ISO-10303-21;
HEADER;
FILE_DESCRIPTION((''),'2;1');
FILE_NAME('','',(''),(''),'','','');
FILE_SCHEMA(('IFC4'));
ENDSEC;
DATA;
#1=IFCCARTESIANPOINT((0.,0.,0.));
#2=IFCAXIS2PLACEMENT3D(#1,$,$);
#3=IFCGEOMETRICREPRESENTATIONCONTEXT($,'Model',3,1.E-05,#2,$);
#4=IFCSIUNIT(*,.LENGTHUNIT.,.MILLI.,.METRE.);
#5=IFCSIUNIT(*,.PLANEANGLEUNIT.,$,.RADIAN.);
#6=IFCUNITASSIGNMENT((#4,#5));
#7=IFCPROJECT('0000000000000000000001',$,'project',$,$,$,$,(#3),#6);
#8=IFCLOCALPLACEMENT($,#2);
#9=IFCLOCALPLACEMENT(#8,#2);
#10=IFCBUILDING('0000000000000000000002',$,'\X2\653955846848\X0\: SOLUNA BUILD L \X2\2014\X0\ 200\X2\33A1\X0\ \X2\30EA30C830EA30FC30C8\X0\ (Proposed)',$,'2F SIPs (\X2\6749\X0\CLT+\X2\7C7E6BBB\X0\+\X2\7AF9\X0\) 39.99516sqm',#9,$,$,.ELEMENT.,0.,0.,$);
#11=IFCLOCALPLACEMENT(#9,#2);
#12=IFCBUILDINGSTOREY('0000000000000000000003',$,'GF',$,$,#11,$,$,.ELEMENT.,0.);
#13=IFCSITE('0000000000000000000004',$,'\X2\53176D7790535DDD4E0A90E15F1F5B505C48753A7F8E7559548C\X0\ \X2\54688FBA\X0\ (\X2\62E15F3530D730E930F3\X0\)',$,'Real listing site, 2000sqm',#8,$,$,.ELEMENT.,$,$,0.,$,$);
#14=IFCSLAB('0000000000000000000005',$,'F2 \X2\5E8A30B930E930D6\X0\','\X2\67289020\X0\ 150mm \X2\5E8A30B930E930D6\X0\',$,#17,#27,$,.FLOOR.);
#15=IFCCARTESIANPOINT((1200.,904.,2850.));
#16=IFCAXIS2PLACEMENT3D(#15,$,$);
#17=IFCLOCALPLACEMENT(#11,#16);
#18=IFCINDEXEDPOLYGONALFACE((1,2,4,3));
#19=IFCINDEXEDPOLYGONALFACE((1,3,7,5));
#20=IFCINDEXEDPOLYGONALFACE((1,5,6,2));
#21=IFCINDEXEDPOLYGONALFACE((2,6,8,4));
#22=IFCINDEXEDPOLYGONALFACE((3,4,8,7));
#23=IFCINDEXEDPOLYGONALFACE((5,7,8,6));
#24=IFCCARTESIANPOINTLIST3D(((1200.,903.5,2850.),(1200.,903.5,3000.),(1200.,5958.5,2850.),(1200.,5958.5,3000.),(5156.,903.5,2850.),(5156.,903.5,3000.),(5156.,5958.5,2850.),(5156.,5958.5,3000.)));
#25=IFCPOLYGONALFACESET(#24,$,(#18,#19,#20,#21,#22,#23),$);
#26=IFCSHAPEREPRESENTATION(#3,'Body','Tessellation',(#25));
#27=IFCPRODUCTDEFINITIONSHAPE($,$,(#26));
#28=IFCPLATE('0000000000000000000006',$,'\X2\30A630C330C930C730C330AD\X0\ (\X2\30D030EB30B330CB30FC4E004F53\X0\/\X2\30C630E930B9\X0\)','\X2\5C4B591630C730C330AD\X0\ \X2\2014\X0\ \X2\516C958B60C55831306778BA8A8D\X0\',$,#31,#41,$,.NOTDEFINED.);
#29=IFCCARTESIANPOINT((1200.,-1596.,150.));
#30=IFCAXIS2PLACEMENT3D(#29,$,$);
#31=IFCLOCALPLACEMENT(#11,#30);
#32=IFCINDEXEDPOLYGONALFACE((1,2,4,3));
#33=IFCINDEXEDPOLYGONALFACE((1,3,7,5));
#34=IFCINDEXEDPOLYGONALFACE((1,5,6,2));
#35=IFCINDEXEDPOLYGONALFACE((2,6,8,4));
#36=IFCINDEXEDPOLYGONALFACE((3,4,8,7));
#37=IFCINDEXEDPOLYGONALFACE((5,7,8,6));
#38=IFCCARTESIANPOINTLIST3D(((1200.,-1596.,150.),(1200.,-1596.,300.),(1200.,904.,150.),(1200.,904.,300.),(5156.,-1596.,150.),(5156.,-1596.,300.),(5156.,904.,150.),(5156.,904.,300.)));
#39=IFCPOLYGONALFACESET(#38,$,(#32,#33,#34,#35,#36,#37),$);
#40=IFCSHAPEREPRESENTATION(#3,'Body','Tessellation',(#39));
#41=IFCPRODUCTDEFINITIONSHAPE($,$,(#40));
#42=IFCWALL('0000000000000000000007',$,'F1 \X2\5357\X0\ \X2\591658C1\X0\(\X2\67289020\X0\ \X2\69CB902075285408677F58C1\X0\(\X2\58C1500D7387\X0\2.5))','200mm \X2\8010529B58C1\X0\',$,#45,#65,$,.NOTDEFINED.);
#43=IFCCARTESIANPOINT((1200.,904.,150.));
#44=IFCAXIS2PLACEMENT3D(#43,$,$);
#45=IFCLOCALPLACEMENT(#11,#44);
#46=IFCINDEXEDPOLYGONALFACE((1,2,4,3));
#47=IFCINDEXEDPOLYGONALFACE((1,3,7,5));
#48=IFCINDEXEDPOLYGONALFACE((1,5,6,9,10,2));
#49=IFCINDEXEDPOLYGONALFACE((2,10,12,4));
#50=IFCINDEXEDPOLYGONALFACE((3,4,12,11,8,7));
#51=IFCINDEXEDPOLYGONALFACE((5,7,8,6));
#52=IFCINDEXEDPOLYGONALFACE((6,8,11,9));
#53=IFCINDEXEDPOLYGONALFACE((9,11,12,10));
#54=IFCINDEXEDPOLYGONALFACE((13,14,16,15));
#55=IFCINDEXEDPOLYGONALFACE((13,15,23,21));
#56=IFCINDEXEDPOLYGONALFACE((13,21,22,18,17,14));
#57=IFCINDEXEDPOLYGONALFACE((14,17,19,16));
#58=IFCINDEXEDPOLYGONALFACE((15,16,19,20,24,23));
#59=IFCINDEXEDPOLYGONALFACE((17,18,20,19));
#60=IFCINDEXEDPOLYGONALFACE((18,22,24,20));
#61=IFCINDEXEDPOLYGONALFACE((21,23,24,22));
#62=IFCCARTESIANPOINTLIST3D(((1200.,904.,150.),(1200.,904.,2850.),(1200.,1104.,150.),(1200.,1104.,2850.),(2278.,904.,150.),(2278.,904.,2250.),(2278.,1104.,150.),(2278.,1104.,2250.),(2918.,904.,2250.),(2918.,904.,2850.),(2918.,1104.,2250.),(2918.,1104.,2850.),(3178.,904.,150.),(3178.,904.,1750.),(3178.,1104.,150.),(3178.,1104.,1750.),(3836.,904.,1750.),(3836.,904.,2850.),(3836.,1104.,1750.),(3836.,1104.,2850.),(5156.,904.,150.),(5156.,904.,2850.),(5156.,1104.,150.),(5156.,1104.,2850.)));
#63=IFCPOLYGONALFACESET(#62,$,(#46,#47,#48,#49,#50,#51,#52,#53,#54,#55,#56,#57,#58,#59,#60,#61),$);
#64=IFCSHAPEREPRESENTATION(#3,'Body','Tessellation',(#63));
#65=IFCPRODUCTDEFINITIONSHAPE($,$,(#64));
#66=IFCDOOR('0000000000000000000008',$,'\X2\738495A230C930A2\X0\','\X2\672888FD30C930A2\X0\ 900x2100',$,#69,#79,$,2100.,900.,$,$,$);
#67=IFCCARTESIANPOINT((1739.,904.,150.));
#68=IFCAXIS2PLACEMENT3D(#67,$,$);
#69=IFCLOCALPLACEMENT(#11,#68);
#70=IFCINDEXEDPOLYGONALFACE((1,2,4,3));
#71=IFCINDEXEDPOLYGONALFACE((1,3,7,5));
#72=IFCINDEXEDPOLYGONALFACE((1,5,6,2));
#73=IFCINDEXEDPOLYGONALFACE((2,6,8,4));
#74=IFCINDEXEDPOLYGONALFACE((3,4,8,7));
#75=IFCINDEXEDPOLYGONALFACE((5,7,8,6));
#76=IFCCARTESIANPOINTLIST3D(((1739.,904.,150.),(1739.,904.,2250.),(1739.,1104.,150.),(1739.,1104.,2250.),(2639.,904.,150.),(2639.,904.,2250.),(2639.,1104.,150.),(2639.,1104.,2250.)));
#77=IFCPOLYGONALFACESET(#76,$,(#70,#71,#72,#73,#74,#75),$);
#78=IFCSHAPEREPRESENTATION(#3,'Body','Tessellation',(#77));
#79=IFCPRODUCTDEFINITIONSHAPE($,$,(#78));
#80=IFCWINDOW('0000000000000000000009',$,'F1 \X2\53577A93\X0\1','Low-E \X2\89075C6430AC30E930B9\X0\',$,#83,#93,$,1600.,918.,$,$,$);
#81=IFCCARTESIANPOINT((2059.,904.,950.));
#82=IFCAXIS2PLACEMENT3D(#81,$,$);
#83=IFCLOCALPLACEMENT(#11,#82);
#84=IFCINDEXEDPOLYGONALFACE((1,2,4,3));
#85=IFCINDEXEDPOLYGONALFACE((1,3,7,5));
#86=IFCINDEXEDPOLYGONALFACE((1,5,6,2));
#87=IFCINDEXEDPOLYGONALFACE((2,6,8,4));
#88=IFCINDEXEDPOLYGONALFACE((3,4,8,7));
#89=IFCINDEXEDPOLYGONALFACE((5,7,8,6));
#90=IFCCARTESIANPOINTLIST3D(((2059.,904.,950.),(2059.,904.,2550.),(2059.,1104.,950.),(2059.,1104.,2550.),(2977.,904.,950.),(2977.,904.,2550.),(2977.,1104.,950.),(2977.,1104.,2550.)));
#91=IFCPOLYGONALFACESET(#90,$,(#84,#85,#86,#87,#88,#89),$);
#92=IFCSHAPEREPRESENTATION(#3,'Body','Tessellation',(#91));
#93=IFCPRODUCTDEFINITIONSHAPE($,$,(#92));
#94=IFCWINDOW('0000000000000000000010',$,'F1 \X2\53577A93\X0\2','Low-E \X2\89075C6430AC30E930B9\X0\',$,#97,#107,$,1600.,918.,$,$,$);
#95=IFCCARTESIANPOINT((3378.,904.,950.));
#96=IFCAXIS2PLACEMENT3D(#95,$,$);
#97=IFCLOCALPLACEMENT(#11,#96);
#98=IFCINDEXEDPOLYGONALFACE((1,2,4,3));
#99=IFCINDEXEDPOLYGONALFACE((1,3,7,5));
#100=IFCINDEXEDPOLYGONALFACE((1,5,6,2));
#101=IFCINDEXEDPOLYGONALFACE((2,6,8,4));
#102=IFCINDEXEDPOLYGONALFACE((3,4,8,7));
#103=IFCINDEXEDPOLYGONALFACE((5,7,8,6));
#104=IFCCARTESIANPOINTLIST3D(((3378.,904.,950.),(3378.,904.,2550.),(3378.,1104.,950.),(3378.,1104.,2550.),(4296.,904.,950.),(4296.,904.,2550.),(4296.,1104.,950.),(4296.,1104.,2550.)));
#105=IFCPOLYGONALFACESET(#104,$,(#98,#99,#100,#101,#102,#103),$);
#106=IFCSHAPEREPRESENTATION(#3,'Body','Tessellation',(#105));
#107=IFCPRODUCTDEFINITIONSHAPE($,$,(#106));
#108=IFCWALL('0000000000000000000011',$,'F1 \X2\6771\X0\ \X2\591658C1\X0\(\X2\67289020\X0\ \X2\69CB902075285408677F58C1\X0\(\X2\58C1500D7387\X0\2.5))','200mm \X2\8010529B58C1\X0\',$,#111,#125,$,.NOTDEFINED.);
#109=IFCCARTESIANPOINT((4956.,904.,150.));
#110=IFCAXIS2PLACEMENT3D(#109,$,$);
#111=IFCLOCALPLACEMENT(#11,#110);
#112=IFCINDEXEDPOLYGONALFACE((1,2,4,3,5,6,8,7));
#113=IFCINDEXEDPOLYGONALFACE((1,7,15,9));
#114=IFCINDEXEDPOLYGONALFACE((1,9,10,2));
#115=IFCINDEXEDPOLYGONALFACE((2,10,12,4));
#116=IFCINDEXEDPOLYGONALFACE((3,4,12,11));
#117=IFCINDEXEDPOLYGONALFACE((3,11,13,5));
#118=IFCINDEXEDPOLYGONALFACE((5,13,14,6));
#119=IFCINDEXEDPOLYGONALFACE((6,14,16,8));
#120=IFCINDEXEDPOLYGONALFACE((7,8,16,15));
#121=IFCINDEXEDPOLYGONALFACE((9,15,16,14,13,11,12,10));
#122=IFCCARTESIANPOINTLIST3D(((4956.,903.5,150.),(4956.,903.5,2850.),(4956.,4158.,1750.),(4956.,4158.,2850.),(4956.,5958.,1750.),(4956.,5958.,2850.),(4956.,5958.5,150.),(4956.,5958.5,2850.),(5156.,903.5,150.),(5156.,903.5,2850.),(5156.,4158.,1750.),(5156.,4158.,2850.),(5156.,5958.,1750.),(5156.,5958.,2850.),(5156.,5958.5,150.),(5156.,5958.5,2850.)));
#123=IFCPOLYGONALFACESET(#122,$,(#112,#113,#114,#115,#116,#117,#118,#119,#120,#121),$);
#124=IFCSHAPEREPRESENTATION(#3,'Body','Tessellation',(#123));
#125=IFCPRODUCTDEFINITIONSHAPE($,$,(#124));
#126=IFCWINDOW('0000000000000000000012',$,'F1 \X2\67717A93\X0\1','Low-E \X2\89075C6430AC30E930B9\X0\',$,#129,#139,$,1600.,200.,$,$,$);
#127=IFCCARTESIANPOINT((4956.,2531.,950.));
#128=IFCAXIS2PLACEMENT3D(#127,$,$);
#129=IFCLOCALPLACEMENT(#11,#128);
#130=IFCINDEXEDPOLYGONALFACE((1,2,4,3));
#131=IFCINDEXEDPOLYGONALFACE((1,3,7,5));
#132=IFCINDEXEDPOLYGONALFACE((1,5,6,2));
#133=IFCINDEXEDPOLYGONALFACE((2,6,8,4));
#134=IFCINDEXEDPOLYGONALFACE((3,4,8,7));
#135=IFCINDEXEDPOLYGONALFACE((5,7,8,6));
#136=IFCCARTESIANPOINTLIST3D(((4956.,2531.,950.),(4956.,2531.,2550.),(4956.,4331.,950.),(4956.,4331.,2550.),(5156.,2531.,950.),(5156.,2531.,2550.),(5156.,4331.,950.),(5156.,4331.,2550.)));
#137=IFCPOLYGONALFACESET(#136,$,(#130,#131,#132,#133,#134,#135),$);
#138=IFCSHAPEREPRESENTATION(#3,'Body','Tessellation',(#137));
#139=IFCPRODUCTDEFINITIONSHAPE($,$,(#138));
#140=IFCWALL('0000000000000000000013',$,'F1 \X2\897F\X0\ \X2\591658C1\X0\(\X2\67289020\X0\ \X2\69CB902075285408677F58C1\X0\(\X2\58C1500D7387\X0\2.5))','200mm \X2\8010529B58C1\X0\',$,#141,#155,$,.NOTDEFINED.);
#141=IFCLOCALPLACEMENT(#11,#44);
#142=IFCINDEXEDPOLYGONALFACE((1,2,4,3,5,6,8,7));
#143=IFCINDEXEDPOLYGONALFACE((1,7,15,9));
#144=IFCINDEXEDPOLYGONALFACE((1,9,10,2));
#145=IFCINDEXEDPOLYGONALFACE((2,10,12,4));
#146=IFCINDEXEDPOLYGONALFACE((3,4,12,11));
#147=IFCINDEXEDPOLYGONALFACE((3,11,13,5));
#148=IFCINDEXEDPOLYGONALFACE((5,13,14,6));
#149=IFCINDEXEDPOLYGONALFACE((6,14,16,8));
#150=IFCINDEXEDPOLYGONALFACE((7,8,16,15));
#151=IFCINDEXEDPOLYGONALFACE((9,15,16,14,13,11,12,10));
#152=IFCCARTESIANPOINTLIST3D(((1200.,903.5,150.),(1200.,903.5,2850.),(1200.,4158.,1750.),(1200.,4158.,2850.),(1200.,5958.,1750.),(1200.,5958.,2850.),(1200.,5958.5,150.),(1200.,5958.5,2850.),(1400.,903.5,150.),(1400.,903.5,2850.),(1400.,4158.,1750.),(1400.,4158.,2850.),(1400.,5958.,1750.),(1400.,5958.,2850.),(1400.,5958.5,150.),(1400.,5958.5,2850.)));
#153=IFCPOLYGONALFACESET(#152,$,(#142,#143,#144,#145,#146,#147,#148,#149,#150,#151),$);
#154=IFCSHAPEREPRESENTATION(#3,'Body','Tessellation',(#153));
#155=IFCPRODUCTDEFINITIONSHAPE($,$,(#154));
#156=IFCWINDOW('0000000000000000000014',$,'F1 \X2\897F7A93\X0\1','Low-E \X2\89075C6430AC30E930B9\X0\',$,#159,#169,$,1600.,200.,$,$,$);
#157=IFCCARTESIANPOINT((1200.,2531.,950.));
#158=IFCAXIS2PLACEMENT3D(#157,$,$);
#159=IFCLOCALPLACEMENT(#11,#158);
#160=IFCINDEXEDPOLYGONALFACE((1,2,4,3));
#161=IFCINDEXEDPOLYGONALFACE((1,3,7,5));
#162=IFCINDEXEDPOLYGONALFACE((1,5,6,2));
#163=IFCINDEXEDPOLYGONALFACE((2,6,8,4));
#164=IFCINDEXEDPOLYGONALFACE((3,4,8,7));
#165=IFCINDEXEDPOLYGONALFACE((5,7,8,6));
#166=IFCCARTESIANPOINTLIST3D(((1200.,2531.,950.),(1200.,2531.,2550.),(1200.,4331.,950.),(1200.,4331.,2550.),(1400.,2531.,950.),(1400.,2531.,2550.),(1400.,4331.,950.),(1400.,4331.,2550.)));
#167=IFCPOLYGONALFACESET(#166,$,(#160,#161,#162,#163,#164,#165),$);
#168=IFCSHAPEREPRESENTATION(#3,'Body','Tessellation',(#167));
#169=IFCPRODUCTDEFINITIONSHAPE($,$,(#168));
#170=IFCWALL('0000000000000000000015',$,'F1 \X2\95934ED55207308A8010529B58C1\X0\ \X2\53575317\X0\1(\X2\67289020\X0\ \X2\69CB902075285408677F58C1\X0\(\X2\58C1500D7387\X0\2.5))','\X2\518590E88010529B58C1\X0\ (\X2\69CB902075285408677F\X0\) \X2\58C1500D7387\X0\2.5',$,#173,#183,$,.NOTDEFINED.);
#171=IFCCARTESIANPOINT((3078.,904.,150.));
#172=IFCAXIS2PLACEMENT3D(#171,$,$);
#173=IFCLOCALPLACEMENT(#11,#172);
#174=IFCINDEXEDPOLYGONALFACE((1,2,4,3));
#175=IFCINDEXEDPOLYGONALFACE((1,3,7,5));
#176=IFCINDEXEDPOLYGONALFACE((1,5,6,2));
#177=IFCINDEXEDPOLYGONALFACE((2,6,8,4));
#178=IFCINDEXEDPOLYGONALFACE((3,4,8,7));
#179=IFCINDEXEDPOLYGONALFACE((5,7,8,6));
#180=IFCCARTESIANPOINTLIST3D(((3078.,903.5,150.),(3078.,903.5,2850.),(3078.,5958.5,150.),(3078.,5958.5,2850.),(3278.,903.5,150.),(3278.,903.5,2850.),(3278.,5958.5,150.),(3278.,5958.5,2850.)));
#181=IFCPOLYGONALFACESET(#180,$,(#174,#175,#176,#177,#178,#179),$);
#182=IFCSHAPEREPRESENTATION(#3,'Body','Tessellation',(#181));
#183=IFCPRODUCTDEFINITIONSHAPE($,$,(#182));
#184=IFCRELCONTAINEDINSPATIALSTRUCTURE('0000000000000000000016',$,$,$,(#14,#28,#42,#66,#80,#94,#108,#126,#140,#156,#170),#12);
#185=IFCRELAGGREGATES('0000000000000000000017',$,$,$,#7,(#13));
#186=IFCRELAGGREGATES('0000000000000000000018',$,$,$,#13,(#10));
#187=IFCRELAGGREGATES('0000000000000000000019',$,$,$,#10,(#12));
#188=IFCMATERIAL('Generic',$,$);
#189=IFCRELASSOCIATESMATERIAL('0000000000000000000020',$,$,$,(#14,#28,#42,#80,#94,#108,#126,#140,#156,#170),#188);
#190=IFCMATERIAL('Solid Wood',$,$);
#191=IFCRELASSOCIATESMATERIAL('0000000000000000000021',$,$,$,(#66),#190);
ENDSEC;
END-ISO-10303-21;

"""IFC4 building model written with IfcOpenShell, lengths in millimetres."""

from ifc_helpers import new_model, si_unit, frame, frame_2d, origin, place, context, project, spatial, rectangle, extrude, material, element, fill, save


model = new_model("IFC4")

# Units and contexts
model_context = context("Model", 3, precision=1e-05, world=origin())
ifc_project = project(units=[si_unit("LENGTHUNIT", "METRE", prefix="MILLI"), si_unit("PLANEANGLEUNIT", "RADIAN")], contexts=[model_context])

# Site, building, storey
site_placement = place(None, origin())
site = spatial("IfcSite", under=ifc_project, at=site_placement, Name="北海道川上郡弟子屈町美留和 周辺 (拡張プラン)", ObjectType="Real listing site, 2000sqm", CompositionType="ELEMENT", RefElevation=0.0)
building_placement = place(site_placement, origin())
building = spatial("IfcBuilding", under=site, at=building_placement, Name="改善案: SOLUNA BUILD L — 200㎡ リトリート (Proposed)", ObjectType="2F SIPs (杉CLT+籾殻+竹) 39.99516sqm", CompositionType="ELEMENT", ElevationOfRefHeight=0.0, ElevationOfTerrain=0.0)
storey_placement = place(building_placement, origin())
storey = spatial("IfcBuildingStorey", under=building, at=storey_placement, Name="GF", CompositionType="ELEMENT", Elevation=0.0)

# Slab
ifc_material_1 = material(Name="Generic")
slab_1_placement = place(storey_placement, frame((1200.0, 904.0, 2850.0)))
element("IfcSlab", 1, at=slab_1_placement, inside=storey, material=ifc_material_1, Name="F2 床スラブ", Description="木造 150mm 床スラブ", PredefinedType="FLOOR", context=model_context, shape_type="SweptSolid", body=[
    extrude(rectangle(XDim=3956.0, YDim=5055.0, at=frame_2d((1978.0, 2527.0))), frame((1200.0, 904.0, 2850.0)), (0.0, 0.0, 1.0), 150.0),
])

# Plate
plate_placement = place(storey_placement, frame((1200.0, -1596.0, 150.0)))
element("IfcPlate", 2, at=plate_placement, inside=storey, material=ifc_material_1, Name="ウッドデッキ (バルコニー一体/テラス)", Description="屋外デッキ — 公開情報で確認", PredefinedType="NOTDEFINED", context=model_context, shape_type="SweptSolid", body=[
    extrude(rectangle(XDim=3956.0, YDim=2500.0, at=frame_2d((1978.0, 1250.0))), frame((1200.0, -1596.0, 150.0)), (0.0, 0.0, 1.0), 150.0),
])

# Wall, openings, door, windows
wall_1_placement = place(storey_placement, frame((1200.0, 904.0, 150.0)))
wall_1 = element("IfcWall", 3, at=wall_1_placement, inside=storey, material=ifc_material_1, Name="F1 南 外壁(木造 構造用合板壁(壁倍率2.5))", Description="200mm 耐力壁", PredefinedType="NOTDEFINED", context=model_context, shape_type="SweptSolid", body=[
    extrude(rectangle(XDim=3956.0, YDim=200.0, at=frame_2d((1978.0, 100.0))), frame((1200.0, 904.0, 150.0)), (0.0, 0.0, 1.0), 2700.0),
])
opening_1_placement = place(storey_placement, frame((1739.0, 904.0, 150.0)))
opening_1 = element("IfcOpeningElement", 4, at=opening_1_placement, cuts=wall_1, PredefinedType="NOTDEFINED", context=model_context, shape_type="SweptSolid", body=[
    extrude(rectangle(XDim=900.0, YDim=200.0, at=frame_2d((450.0, 100.0))), frame((1739.0, 904.0, 150.0)), (0.0, 0.0, 1.0), 2100.0),
])
opening_2_placement = place(storey_placement, frame((2059.0, 904.0, 950.0)))
opening_2 = element("IfcOpeningElement", 5, at=opening_2_placement, cuts=wall_1, PredefinedType="NOTDEFINED", context=model_context, shape_type="SweptSolid", body=[
    extrude(rectangle(XDim=918.0, YDim=200.0, at=frame_2d((459.0, 100.0))), frame((2059.0, 904.0, 950.0)), (0.0, 0.0, 1.0), 1600.0),
])
opening_3_placement = place(storey_placement, frame((3378.0, 904.0, 950.0)))
opening_3 = element("IfcOpeningElement", 6, at=opening_3_placement, cuts=wall_1, PredefinedType="NOTDEFINED", context=model_context, shape_type="SweptSolid", body=[
    extrude(rectangle(XDim=918.0, YDim=200.0, at=frame_2d((459.0, 100.0))), frame((3378.0, 904.0, 950.0)), (0.0, 0.0, 1.0), 1600.0),
])
ifc_material_2 = material(Name="Solid Wood")
door_placement = place(storey_placement, frame((1739.0, 904.0, 150.0)))
door = element("IfcDoor", 7, at=door_placement, inside=storey, material=ifc_material_2, Name="玄関ドア", Description="木製ドア 900x2100", OverallHeight=2100.0, OverallWidth=900.0, context=model_context, shape_type="SweptSolid", body=[
    extrude(rectangle(XDim=900.0, YDim=200.0, at=frame_2d((450.0, 100.0))), frame((1739.0, 904.0, 150.0)), (0.0, 0.0, 1.0), 2100.0),
])
fill(opening_1, door)
window_1_placement = place(storey_placement, frame((2059.0, 904.0, 950.0)))
window_1 = element("IfcWindow", 8, at=window_1_placement, inside=storey, material=ifc_material_1, Name="F1 南窓1", Description="Low-E 複層ガラス", OverallHeight=1600.0, OverallWidth=918.0, context=model_context, shape_type="SweptSolid", body=[
    extrude(rectangle(XDim=918.0, YDim=200.0, at=frame_2d((459.0, 100.0))), frame((2059.0, 904.0, 950.0)), (0.0, 0.0, 1.0), 1600.0),
])
fill(opening_2, window_1)
window_2_placement = place(storey_placement, frame((3378.0, 904.0, 950.0)))
window_2 = element("IfcWindow", 9, at=window_2_placement, inside=storey, material=ifc_material_1, Name="F1 南窓2", Description="Low-E 複層ガラス", OverallHeight=1600.0, OverallWidth=918.0, context=model_context, shape_type="SweptSolid", body=[
    extrude(rectangle(XDim=918.0, YDim=200.0, at=frame_2d((459.0, 100.0))), frame((3378.0, 904.0, 950.0)), (0.0, 0.0, 1.0), 1600.0),
])
fill(opening_3, window_2)

# Walls, openings, windows
wall_2_placement = place(storey_placement, frame((4956.0, 904.0, 150.0)))
wall_2 = element("IfcWall", 10, at=wall_2_placement, inside=storey, material=ifc_material_1, Name="F1 東 外壁(木造 構造用合板壁(壁倍率2.5))", Description="200mm 耐力壁", PredefinedType="NOTDEFINED", context=model_context, shape_type="SweptSolid", body=[
    extrude(rectangle(XDim=200.0, YDim=5055.0, at=frame_2d((100.0, 2527.0))), frame((4956.0, 904.0, 150.0)), (0.0, 0.0, 1.0), 2700.0),
])
opening_4_placement = place(storey_placement, frame((4956.0, 2531.0, 950.0)))
opening_4 = element("IfcOpeningElement", 11, at=opening_4_placement, cuts=wall_2, PredefinedType="NOTDEFINED", context=model_context, shape_type="SweptSolid", body=[
    extrude(rectangle(XDim=200.0, YDim=1800.0, at=frame_2d((100.0, 900.0))), frame((4956.0, 2531.0, 950.0)), (0.0, 0.0, 1.0), 1600.0),
])
window_3_placement = place(storey_placement, frame((4956.0, 2531.0, 950.0)))
window_3 = element("IfcWindow", 12, at=window_3_placement, inside=storey, material=ifc_material_1, Name="F1 東窓1", Description="Low-E 複層ガラス", OverallHeight=1600.0, OverallWidth=200.0, context=model_context, shape_type="SweptSolid", body=[
    extrude(rectangle(XDim=200.0, YDim=1800.0, at=frame_2d((100.0, 900.0))), frame((4956.0, 2531.0, 950.0)), (0.0, 0.0, 1.0), 1600.0),
])
fill(opening_4, window_3)
wall_3_placement = place(storey_placement, frame((1200.0, 904.0, 150.0)))
wall_3 = element("IfcWall", 13, at=wall_3_placement, inside=storey, material=ifc_material_1, Name="F1 西 外壁(木造 構造用合板壁(壁倍率2.5))", Description="200mm 耐力壁", PredefinedType="NOTDEFINED", context=model_context, shape_type="SweptSolid", body=[
    extrude(rectangle(XDim=200.0, YDim=5055.0, at=frame_2d((100.0, 2527.0))), frame((1200.0, 904.0, 150.0)), (0.0, 0.0, 1.0), 2700.0),
])
opening_5_placement = place(storey_placement, frame((1200.0, 2531.0, 950.0)))
opening_5 = element("IfcOpeningElement", 14, at=opening_5_placement, cuts=wall_3, PredefinedType="NOTDEFINED", context=model_context, shape_type="SweptSolid", body=[
    extrude(rectangle(XDim=200.0, YDim=1800.0, at=frame_2d((100.0, 900.0))), frame((1200.0, 2531.0, 950.0)), (0.0, 0.0, 1.0), 1600.0),
])
window_4_placement = place(storey_placement, frame((1200.0, 2531.0, 950.0)))
window_4 = element("IfcWindow", 15, at=window_4_placement, inside=storey, material=ifc_material_1, Name="F1 西窓1", Description="Low-E 複層ガラス", OverallHeight=1600.0, OverallWidth=200.0, context=model_context, shape_type="SweptSolid", body=[
    extrude(rectangle(XDim=200.0, YDim=1800.0, at=frame_2d((100.0, 900.0))), frame((1200.0, 2531.0, 950.0)), (0.0, 0.0, 1.0), 1600.0),
])
fill(opening_5, window_4)

# Wall
wall_4_placement = place(storey_placement, frame((3078.0, 904.0, 150.0)))
element("IfcWall", 16, at=wall_4_placement, inside=storey, material=ifc_material_1, Name="F1 間仕切り耐力壁 南北1(木造 構造用合板壁(壁倍率2.5))", Description="内部耐力壁 (構造用合板) 壁倍率2.5", PredefinedType="NOTDEFINED", context=model_context, shape_type="SweptSolid", body=[
    extrude(rectangle(XDim=200.0, YDim=5055.0, at=frame_2d((100.0, 2527.0))), frame((3078.0, 904.0, 150.0)), (0.0, 0.0, 1.0), 2700.0),
])

save(model, "model.ifc")
